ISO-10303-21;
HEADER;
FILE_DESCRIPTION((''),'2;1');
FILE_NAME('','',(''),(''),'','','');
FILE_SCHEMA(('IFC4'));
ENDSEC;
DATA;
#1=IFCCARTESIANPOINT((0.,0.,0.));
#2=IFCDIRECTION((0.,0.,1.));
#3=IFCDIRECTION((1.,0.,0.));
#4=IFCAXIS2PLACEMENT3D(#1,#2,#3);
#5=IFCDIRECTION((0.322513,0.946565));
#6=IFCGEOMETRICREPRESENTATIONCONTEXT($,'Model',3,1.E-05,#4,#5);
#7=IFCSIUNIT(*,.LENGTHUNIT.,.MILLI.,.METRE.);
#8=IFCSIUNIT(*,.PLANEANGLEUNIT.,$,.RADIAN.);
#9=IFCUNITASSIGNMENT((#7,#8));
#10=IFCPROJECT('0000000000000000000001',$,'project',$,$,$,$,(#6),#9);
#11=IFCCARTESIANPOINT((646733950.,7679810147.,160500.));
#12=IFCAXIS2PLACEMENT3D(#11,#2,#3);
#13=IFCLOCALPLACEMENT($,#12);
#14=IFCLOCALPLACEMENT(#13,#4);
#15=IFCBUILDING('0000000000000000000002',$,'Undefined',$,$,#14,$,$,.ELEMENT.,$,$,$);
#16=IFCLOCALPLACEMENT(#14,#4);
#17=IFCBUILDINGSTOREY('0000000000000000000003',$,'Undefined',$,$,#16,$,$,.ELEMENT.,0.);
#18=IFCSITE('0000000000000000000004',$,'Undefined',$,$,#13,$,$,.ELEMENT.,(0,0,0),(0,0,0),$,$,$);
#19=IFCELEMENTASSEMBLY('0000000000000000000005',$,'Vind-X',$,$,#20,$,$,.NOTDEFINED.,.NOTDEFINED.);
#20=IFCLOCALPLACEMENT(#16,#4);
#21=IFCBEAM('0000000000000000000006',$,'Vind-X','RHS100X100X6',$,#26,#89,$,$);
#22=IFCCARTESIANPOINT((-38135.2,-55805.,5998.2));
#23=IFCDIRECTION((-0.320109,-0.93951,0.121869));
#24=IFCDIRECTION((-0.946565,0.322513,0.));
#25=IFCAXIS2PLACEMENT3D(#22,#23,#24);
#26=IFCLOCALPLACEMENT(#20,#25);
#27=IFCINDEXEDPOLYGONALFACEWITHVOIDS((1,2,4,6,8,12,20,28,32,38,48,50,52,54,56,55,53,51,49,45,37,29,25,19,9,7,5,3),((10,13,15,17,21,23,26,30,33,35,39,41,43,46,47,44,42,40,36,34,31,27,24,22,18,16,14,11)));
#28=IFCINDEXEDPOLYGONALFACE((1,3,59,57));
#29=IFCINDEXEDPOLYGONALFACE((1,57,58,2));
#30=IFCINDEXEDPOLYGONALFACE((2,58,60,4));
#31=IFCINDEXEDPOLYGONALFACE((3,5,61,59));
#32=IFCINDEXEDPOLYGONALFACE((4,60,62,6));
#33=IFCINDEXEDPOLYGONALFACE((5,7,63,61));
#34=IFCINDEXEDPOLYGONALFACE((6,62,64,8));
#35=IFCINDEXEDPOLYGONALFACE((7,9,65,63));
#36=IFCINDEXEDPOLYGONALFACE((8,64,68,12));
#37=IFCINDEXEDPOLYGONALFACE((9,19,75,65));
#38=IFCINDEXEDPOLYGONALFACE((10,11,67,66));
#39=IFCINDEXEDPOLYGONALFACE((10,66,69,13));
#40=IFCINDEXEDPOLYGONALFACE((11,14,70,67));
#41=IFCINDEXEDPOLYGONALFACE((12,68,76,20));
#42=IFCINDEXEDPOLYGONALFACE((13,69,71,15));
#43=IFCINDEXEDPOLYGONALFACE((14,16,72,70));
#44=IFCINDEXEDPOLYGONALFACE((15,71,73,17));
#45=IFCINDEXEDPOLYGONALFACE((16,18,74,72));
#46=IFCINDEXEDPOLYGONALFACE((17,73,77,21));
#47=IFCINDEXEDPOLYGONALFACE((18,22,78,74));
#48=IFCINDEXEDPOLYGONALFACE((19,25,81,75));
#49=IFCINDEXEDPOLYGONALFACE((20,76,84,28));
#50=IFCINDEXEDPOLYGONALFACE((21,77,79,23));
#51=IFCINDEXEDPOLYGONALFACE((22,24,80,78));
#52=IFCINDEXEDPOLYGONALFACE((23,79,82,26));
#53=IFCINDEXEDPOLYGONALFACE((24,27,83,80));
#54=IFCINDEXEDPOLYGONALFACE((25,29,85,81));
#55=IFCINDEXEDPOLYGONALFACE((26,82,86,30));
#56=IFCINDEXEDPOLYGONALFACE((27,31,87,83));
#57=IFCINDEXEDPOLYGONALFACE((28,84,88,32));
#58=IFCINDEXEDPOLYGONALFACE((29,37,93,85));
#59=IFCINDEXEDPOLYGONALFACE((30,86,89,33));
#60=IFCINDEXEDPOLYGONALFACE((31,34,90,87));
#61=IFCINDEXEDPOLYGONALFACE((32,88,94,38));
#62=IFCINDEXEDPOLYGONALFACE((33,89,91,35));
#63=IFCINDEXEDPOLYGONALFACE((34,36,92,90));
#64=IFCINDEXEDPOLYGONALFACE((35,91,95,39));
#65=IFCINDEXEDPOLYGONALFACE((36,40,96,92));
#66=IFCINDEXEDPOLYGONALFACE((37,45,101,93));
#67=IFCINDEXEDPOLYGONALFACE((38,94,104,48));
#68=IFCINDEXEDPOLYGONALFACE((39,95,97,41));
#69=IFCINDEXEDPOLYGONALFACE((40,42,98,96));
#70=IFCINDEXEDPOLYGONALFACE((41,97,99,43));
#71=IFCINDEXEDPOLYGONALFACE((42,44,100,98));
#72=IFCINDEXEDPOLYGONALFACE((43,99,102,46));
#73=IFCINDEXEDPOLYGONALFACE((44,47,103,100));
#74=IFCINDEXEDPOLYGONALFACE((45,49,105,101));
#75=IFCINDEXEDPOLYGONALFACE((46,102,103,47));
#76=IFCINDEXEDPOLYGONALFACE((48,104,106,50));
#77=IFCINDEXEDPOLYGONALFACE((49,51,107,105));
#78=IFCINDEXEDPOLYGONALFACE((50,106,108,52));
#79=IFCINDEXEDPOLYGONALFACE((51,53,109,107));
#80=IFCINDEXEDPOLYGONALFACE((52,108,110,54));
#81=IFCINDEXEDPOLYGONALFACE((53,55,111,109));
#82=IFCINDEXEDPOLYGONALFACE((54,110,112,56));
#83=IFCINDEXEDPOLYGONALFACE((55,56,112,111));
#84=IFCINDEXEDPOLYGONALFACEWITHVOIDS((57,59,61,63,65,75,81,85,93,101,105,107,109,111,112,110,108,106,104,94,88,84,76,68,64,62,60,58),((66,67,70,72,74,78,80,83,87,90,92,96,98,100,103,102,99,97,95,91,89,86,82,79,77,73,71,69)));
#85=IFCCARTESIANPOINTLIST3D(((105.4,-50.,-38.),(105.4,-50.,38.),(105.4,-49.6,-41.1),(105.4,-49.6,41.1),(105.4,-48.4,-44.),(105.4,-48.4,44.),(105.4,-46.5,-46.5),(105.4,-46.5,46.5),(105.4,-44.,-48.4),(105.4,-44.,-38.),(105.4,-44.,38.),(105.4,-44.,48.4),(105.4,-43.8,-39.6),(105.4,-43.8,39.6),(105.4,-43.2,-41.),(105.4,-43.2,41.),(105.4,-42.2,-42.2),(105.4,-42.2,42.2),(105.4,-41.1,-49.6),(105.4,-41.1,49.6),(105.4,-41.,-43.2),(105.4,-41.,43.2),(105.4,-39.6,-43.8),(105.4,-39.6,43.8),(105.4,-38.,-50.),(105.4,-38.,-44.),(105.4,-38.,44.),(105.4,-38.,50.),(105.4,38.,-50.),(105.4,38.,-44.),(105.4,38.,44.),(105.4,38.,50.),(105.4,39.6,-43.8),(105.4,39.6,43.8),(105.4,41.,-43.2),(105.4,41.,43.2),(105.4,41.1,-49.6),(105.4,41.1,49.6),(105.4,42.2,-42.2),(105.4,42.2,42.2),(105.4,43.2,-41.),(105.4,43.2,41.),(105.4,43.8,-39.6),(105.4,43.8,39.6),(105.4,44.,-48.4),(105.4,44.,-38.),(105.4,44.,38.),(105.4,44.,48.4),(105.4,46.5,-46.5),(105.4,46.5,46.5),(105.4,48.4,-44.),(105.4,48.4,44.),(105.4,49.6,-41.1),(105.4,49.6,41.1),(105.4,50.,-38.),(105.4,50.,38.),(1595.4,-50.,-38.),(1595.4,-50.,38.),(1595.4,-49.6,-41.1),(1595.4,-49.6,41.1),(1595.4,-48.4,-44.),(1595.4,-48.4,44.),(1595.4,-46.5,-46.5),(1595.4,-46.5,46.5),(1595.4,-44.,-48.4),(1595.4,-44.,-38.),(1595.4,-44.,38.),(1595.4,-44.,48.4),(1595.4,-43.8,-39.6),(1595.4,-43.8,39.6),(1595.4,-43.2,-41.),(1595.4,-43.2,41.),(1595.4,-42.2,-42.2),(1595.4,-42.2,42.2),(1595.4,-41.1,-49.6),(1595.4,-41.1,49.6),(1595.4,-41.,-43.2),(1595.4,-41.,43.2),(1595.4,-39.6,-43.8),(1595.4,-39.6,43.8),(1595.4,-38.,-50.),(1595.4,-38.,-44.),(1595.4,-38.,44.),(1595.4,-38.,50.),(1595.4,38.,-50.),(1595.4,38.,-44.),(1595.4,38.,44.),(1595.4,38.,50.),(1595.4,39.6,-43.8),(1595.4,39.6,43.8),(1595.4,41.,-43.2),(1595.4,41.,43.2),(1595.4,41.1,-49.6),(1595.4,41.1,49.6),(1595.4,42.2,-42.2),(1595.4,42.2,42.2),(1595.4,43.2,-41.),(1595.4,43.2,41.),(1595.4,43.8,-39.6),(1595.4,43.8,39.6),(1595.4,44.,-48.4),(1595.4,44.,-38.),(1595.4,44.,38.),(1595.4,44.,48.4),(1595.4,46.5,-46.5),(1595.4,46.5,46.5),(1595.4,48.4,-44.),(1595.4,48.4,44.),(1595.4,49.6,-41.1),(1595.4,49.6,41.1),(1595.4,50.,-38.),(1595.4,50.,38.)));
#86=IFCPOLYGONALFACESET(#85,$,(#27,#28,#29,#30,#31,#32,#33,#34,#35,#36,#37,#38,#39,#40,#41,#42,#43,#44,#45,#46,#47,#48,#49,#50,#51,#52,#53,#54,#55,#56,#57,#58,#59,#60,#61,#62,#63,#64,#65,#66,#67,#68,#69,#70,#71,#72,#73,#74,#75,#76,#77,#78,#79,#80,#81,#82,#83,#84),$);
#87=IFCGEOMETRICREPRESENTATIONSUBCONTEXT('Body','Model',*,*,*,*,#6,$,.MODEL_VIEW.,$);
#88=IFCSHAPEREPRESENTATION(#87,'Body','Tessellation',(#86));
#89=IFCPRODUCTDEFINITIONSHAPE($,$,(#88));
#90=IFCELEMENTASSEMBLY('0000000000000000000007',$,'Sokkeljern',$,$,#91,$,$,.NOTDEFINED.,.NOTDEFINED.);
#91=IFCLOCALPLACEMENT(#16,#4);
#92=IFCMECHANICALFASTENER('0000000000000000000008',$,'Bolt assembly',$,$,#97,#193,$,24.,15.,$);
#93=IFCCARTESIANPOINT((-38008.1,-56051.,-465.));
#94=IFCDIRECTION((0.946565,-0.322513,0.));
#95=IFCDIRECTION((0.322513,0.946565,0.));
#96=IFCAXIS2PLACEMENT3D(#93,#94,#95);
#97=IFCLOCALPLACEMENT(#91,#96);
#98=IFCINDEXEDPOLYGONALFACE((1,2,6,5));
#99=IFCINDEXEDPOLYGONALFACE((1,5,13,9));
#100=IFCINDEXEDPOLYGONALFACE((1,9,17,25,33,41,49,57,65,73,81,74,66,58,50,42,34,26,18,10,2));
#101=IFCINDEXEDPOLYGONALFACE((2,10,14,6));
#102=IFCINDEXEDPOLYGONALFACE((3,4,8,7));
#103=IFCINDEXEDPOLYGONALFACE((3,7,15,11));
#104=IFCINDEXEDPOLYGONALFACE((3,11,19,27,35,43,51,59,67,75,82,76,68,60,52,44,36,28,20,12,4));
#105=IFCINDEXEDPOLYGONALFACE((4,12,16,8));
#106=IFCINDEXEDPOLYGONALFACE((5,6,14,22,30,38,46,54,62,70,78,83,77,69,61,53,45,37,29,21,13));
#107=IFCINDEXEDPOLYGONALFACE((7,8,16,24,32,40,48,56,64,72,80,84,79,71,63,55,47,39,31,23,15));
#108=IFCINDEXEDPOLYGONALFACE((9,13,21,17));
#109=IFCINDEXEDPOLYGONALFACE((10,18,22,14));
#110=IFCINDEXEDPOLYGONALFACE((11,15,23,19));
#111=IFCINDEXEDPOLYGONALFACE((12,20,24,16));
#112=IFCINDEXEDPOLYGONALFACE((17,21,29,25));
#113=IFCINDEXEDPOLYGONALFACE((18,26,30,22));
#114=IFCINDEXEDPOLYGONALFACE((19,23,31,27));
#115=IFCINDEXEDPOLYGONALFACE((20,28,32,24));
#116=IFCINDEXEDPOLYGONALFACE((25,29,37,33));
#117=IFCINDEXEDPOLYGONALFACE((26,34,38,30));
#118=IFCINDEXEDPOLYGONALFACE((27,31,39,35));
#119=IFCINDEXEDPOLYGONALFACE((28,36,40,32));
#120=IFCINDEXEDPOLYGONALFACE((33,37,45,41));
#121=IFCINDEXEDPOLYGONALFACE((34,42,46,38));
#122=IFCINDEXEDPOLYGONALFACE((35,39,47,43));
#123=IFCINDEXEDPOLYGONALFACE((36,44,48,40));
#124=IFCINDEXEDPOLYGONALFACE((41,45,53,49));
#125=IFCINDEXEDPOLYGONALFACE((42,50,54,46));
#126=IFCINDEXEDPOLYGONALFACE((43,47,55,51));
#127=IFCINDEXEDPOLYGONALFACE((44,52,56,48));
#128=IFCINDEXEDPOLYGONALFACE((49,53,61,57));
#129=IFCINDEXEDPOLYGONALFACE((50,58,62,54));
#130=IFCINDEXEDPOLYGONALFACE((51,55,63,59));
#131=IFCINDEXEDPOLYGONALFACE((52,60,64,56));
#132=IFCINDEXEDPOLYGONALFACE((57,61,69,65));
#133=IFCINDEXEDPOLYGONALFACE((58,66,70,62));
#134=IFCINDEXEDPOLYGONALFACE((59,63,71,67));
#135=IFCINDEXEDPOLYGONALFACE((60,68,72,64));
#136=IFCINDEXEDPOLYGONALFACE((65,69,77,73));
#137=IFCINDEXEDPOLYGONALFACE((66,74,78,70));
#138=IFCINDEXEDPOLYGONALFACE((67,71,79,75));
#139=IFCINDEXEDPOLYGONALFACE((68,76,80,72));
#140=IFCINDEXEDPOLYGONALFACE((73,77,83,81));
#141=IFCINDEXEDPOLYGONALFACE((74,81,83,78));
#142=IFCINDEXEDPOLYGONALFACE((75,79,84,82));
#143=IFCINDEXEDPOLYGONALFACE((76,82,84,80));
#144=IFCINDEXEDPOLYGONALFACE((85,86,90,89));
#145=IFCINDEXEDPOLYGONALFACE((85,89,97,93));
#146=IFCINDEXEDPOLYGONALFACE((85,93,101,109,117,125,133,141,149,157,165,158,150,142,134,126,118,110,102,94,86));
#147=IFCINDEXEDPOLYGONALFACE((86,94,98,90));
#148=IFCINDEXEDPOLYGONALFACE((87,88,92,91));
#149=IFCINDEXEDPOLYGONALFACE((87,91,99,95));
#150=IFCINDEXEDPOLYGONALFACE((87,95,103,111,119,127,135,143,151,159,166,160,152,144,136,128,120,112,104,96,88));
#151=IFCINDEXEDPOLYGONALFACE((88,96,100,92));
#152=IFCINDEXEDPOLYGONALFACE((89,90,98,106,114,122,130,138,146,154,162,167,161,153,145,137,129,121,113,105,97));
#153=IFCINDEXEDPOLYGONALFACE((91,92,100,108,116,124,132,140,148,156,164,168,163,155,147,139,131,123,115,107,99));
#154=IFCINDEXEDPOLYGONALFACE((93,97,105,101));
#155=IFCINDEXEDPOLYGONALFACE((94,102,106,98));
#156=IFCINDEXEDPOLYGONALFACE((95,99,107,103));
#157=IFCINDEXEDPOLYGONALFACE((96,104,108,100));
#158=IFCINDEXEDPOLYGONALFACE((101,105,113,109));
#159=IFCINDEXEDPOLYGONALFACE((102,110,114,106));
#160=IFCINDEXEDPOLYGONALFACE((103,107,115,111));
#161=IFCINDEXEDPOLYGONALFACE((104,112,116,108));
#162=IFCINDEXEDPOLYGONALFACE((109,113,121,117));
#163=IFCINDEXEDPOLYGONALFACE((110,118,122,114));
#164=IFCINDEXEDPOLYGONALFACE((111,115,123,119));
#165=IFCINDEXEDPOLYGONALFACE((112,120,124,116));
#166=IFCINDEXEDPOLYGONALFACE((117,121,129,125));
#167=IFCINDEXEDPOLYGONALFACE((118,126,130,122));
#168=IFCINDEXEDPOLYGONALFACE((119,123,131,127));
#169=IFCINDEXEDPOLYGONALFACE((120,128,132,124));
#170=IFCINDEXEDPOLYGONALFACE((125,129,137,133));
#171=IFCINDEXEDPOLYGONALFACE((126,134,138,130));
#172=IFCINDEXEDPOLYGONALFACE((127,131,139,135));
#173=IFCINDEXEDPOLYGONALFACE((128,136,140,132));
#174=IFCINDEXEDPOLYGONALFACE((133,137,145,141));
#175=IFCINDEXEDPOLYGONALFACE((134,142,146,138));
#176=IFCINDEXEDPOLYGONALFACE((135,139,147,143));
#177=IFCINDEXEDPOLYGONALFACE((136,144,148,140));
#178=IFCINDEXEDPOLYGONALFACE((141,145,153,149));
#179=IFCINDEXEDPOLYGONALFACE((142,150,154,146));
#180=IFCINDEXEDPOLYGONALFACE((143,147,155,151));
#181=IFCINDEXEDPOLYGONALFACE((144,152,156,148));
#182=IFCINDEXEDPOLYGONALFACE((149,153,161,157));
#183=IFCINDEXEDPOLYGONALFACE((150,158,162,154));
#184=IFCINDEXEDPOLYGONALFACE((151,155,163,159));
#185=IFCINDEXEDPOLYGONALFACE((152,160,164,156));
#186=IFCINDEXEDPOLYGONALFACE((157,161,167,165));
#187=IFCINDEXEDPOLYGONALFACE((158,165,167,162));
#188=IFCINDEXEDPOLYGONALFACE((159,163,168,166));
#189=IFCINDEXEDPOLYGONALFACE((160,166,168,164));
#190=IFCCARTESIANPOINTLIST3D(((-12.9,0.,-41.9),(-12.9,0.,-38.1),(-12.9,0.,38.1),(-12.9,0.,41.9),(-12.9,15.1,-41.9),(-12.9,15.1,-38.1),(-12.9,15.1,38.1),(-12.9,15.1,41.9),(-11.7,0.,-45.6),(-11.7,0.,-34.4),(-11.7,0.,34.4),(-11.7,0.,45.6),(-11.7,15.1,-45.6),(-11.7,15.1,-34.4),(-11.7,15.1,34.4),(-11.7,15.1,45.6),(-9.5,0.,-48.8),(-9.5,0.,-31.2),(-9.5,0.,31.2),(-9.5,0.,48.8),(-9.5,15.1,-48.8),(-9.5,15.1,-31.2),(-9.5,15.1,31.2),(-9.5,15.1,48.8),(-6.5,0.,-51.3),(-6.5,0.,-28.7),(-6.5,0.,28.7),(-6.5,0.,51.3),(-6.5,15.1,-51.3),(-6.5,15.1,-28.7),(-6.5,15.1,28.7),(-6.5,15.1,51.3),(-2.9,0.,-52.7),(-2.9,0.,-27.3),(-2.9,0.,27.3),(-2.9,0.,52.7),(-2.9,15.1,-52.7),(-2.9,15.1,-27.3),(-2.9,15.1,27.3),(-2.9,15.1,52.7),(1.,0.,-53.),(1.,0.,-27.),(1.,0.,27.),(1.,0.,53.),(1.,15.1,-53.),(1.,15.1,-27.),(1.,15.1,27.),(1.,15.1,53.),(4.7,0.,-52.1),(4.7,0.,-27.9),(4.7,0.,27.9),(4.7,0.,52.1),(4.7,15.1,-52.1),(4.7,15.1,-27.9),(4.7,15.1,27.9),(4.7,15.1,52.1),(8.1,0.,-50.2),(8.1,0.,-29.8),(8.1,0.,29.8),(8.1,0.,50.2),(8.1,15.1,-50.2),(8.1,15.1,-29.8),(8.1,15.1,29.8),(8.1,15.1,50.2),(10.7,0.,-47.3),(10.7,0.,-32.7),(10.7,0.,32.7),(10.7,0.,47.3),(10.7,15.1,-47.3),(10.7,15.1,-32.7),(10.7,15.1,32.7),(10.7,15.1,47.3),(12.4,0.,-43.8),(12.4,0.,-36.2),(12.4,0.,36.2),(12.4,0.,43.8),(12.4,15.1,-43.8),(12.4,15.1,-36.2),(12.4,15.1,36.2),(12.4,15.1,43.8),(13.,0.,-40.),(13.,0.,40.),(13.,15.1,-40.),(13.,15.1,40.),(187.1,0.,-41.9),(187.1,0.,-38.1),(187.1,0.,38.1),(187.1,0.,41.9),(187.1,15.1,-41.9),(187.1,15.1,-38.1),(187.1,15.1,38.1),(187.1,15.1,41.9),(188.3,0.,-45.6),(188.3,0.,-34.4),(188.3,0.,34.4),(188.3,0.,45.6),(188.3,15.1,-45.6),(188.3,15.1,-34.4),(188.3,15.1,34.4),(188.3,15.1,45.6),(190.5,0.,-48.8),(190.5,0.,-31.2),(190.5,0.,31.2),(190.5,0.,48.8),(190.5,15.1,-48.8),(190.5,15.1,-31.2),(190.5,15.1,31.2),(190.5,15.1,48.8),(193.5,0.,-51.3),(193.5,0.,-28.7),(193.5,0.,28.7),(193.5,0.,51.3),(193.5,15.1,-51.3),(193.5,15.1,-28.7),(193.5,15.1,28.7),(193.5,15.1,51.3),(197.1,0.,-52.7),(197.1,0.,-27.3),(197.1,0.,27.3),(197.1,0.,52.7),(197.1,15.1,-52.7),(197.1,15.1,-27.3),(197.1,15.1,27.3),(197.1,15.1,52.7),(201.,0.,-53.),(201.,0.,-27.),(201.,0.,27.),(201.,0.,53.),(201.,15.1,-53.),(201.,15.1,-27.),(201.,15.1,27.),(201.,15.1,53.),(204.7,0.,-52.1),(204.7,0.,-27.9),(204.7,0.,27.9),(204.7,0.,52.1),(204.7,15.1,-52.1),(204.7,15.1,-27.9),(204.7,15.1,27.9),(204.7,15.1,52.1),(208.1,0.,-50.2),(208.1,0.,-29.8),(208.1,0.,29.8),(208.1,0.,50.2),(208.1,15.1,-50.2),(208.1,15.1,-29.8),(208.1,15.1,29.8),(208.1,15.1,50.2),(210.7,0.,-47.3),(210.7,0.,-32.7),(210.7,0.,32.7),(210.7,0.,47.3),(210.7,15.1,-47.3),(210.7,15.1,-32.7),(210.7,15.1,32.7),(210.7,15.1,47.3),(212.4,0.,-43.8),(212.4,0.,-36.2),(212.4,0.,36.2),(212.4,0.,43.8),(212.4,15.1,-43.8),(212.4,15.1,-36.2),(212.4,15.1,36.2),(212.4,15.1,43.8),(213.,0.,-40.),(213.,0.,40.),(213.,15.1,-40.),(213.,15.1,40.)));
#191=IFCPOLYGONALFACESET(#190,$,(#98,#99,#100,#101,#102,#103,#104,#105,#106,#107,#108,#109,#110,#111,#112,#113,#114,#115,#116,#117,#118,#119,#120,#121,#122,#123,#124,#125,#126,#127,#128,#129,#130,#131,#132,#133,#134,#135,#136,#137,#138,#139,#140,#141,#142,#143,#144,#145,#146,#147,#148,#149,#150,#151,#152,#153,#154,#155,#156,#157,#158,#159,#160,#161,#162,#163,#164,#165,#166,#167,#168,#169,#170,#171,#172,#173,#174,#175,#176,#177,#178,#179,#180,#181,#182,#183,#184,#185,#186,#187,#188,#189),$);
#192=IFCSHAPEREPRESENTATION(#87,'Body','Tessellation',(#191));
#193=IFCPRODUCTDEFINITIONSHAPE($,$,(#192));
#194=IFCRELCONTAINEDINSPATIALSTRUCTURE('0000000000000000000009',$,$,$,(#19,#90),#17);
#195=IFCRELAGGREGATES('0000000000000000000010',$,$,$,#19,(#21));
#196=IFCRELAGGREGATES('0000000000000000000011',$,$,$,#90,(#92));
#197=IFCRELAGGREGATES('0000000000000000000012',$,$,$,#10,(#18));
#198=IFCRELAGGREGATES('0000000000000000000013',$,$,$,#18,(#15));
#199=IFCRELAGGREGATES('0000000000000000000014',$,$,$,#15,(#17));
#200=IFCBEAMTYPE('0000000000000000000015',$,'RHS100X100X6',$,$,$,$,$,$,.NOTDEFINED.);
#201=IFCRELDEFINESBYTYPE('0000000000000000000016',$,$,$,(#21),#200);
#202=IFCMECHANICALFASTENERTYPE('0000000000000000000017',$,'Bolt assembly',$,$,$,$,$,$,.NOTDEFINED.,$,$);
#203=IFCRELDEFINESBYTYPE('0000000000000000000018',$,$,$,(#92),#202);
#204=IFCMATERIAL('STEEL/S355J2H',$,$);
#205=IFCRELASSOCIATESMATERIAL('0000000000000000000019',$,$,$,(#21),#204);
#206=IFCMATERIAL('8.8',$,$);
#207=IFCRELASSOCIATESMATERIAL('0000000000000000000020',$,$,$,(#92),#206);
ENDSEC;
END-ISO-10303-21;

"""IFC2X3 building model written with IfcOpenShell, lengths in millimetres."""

from ifc_helpers import new_model, si_unit, direction, frame, origin_with_axes, origin_2d_with_axis, place, context, subcontext, project, spatial, hollow_rectangle, circle, extrude, clip, halfspace, source, transform, mapped, material, type_object, element, aggregate, save


model = new_model("IFC2X3")

# Units and contexts
model_context = context("Model", 3, precision=1e-05, world=origin_with_axes(), true_north=direction((0.322513, 0.946565)))
body_context = subcontext(model_context, "Body", "Model", "MODEL_VIEW")
ifc_project = project(units=[si_unit("LENGTHUNIT", "METRE", prefix="MILLI"), si_unit("PLANEANGLEUNIT", "RADIAN")], contexts=[model_context])

# Site, building, storey
site_placement = place(None, frame((646733950.0, 7679810147.0, 160500.0), z_axis=(0.0, 0.0, 1.0), x_axis=(1.0, 0.0, 0.0)))
site = spatial("IfcSite", under=ifc_project, at=site_placement, Name="Undefined", CompositionType="ELEMENT", RefLatitude=(0, 0, 0), RefLongitude=(0, 0, 0))
building_placement = place(site_placement, origin_with_axes())
building = spatial("IfcBuilding", under=site, at=building_placement, Name="Undefined", CompositionType="ELEMENT")
storey_placement = place(building_placement, origin_with_axes())
storey = spatial("IfcBuildingStorey", under=building, at=storey_placement, Name="Undefined", CompositionType="ELEMENT", Elevation=0.0)

# Element assembly, beam
assembly_1_placement = place(storey_placement, origin_with_axes())
assembly_1 = element("IfcElementAssembly", 1, at=assembly_1_placement, inside=storey, Name="Vind-X", AssemblyPlace="NOTDEFINED", PredefinedType="NOTDEFINED")
ifc_material_1 = material(Name="STEEL/S355J2H")
beam_type_1 = type_object("IfcBeamType", Name="RHS100X100X6", PredefinedType="NOTDEFINED")
beam_1_placement = place(assembly_1_placement, frame((-38135.2, -55805.0, 5998.2), z_axis=(-0.320109, -0.93951, 0.121869), x_axis=(-0.946565, 0.322513, 0.0)))
beam_1 = element("IfcBeam", 2, at=beam_1_placement, type_object=beam_type_1, material=ifc_material_1, Name="Vind-X", Description="RHS100X100X6", context=body_context, shape_type="Clipping", body=[
    clip(clip(extrude(hollow_rectangle(XDim=100.0, YDim=100.0, WallThickness=6.0, InnerFilletRadius=6.0, OuterFilletRadius=12.0, at=origin_2d_with_axis()), frame((1745.0, 0.0, 0.0), z_axis=(-1.0, 0.0, 0.0), x_axis=(0.0, -1.0, 0.0)), (0.0, 0.0, 1.0), 1745.0), halfspace(frame((1595.4, 22.5, 0.0), z_axis=(-1.0, 0.0, 0.0), x_axis=(0.0, -1.0, 0.0)), True)), halfspace(frame((105.4, 22.5, 0.0), z_axis=(1.0, 0.0, 0.0), x_axis=(0.0, 0.0, -1.0)), True)),
])

# Element assembly
assembly_2_placement = place(storey_placement, origin_with_axes())
assembly_2 = element("IfcElementAssembly", 3, at=assembly_2_placement, inside=storey, Name="Sokkeljern", AssemblyPlace="NOTDEFINED", PredefinedType="NOTDEFINED")

# Mechanical fastener
ifc_material_2 = material(Name="8.8")
mechanical_fastener_type = type_object("IfcMechanicalFastenerType", Name="Bolt assembly")
aggregate(assembly_1, [beam_1])
shared_shape_1 = source(origin_with_axes(), body_context, "Body", "SweptSolid", [
    extrude(circle(Radius=13.0, at=origin_2d_with_axis()), frame((0.0, 0.0, 0.0), z_axis=(0.0, 1.0, 0.0), x_axis=(1.0, 0.0, 0.0)), (0.0, 0.0, 1.0), 15.1),
])
mechanical_fastener_1_placement = place(assembly_2_placement, frame((-38008.1, -56051.0, -465.0), z_axis=(0.946565, -0.322513, 0.0), x_axis=(0.322513, 0.946565, 0.0)))
mechanical_fastener_1 = element("IfcMechanicalFastener", 4, at=mechanical_fastener_1_placement, type_object=mechanical_fastener_type, material=ifc_material_2, Name="Bolt assembly", NominalDiameter=24.0, NominalLength=15.0, context=body_context, shape_type="MappedRepresentation", body=[
    mapped(shared_shape_1, transform((0.0, 0.0, -40.0))),
    mapped(shared_shape_1, transform((200.0, 0.0, -40.0))),
    mapped(shared_shape_1, transform((0.0, 0.0, 40.0))),
    mapped(shared_shape_1, transform((200.0, 0.0, 40.0))),
])
aggregate(assembly_2, [mechanical_fastener_1])

save(model, "model.ifc")
